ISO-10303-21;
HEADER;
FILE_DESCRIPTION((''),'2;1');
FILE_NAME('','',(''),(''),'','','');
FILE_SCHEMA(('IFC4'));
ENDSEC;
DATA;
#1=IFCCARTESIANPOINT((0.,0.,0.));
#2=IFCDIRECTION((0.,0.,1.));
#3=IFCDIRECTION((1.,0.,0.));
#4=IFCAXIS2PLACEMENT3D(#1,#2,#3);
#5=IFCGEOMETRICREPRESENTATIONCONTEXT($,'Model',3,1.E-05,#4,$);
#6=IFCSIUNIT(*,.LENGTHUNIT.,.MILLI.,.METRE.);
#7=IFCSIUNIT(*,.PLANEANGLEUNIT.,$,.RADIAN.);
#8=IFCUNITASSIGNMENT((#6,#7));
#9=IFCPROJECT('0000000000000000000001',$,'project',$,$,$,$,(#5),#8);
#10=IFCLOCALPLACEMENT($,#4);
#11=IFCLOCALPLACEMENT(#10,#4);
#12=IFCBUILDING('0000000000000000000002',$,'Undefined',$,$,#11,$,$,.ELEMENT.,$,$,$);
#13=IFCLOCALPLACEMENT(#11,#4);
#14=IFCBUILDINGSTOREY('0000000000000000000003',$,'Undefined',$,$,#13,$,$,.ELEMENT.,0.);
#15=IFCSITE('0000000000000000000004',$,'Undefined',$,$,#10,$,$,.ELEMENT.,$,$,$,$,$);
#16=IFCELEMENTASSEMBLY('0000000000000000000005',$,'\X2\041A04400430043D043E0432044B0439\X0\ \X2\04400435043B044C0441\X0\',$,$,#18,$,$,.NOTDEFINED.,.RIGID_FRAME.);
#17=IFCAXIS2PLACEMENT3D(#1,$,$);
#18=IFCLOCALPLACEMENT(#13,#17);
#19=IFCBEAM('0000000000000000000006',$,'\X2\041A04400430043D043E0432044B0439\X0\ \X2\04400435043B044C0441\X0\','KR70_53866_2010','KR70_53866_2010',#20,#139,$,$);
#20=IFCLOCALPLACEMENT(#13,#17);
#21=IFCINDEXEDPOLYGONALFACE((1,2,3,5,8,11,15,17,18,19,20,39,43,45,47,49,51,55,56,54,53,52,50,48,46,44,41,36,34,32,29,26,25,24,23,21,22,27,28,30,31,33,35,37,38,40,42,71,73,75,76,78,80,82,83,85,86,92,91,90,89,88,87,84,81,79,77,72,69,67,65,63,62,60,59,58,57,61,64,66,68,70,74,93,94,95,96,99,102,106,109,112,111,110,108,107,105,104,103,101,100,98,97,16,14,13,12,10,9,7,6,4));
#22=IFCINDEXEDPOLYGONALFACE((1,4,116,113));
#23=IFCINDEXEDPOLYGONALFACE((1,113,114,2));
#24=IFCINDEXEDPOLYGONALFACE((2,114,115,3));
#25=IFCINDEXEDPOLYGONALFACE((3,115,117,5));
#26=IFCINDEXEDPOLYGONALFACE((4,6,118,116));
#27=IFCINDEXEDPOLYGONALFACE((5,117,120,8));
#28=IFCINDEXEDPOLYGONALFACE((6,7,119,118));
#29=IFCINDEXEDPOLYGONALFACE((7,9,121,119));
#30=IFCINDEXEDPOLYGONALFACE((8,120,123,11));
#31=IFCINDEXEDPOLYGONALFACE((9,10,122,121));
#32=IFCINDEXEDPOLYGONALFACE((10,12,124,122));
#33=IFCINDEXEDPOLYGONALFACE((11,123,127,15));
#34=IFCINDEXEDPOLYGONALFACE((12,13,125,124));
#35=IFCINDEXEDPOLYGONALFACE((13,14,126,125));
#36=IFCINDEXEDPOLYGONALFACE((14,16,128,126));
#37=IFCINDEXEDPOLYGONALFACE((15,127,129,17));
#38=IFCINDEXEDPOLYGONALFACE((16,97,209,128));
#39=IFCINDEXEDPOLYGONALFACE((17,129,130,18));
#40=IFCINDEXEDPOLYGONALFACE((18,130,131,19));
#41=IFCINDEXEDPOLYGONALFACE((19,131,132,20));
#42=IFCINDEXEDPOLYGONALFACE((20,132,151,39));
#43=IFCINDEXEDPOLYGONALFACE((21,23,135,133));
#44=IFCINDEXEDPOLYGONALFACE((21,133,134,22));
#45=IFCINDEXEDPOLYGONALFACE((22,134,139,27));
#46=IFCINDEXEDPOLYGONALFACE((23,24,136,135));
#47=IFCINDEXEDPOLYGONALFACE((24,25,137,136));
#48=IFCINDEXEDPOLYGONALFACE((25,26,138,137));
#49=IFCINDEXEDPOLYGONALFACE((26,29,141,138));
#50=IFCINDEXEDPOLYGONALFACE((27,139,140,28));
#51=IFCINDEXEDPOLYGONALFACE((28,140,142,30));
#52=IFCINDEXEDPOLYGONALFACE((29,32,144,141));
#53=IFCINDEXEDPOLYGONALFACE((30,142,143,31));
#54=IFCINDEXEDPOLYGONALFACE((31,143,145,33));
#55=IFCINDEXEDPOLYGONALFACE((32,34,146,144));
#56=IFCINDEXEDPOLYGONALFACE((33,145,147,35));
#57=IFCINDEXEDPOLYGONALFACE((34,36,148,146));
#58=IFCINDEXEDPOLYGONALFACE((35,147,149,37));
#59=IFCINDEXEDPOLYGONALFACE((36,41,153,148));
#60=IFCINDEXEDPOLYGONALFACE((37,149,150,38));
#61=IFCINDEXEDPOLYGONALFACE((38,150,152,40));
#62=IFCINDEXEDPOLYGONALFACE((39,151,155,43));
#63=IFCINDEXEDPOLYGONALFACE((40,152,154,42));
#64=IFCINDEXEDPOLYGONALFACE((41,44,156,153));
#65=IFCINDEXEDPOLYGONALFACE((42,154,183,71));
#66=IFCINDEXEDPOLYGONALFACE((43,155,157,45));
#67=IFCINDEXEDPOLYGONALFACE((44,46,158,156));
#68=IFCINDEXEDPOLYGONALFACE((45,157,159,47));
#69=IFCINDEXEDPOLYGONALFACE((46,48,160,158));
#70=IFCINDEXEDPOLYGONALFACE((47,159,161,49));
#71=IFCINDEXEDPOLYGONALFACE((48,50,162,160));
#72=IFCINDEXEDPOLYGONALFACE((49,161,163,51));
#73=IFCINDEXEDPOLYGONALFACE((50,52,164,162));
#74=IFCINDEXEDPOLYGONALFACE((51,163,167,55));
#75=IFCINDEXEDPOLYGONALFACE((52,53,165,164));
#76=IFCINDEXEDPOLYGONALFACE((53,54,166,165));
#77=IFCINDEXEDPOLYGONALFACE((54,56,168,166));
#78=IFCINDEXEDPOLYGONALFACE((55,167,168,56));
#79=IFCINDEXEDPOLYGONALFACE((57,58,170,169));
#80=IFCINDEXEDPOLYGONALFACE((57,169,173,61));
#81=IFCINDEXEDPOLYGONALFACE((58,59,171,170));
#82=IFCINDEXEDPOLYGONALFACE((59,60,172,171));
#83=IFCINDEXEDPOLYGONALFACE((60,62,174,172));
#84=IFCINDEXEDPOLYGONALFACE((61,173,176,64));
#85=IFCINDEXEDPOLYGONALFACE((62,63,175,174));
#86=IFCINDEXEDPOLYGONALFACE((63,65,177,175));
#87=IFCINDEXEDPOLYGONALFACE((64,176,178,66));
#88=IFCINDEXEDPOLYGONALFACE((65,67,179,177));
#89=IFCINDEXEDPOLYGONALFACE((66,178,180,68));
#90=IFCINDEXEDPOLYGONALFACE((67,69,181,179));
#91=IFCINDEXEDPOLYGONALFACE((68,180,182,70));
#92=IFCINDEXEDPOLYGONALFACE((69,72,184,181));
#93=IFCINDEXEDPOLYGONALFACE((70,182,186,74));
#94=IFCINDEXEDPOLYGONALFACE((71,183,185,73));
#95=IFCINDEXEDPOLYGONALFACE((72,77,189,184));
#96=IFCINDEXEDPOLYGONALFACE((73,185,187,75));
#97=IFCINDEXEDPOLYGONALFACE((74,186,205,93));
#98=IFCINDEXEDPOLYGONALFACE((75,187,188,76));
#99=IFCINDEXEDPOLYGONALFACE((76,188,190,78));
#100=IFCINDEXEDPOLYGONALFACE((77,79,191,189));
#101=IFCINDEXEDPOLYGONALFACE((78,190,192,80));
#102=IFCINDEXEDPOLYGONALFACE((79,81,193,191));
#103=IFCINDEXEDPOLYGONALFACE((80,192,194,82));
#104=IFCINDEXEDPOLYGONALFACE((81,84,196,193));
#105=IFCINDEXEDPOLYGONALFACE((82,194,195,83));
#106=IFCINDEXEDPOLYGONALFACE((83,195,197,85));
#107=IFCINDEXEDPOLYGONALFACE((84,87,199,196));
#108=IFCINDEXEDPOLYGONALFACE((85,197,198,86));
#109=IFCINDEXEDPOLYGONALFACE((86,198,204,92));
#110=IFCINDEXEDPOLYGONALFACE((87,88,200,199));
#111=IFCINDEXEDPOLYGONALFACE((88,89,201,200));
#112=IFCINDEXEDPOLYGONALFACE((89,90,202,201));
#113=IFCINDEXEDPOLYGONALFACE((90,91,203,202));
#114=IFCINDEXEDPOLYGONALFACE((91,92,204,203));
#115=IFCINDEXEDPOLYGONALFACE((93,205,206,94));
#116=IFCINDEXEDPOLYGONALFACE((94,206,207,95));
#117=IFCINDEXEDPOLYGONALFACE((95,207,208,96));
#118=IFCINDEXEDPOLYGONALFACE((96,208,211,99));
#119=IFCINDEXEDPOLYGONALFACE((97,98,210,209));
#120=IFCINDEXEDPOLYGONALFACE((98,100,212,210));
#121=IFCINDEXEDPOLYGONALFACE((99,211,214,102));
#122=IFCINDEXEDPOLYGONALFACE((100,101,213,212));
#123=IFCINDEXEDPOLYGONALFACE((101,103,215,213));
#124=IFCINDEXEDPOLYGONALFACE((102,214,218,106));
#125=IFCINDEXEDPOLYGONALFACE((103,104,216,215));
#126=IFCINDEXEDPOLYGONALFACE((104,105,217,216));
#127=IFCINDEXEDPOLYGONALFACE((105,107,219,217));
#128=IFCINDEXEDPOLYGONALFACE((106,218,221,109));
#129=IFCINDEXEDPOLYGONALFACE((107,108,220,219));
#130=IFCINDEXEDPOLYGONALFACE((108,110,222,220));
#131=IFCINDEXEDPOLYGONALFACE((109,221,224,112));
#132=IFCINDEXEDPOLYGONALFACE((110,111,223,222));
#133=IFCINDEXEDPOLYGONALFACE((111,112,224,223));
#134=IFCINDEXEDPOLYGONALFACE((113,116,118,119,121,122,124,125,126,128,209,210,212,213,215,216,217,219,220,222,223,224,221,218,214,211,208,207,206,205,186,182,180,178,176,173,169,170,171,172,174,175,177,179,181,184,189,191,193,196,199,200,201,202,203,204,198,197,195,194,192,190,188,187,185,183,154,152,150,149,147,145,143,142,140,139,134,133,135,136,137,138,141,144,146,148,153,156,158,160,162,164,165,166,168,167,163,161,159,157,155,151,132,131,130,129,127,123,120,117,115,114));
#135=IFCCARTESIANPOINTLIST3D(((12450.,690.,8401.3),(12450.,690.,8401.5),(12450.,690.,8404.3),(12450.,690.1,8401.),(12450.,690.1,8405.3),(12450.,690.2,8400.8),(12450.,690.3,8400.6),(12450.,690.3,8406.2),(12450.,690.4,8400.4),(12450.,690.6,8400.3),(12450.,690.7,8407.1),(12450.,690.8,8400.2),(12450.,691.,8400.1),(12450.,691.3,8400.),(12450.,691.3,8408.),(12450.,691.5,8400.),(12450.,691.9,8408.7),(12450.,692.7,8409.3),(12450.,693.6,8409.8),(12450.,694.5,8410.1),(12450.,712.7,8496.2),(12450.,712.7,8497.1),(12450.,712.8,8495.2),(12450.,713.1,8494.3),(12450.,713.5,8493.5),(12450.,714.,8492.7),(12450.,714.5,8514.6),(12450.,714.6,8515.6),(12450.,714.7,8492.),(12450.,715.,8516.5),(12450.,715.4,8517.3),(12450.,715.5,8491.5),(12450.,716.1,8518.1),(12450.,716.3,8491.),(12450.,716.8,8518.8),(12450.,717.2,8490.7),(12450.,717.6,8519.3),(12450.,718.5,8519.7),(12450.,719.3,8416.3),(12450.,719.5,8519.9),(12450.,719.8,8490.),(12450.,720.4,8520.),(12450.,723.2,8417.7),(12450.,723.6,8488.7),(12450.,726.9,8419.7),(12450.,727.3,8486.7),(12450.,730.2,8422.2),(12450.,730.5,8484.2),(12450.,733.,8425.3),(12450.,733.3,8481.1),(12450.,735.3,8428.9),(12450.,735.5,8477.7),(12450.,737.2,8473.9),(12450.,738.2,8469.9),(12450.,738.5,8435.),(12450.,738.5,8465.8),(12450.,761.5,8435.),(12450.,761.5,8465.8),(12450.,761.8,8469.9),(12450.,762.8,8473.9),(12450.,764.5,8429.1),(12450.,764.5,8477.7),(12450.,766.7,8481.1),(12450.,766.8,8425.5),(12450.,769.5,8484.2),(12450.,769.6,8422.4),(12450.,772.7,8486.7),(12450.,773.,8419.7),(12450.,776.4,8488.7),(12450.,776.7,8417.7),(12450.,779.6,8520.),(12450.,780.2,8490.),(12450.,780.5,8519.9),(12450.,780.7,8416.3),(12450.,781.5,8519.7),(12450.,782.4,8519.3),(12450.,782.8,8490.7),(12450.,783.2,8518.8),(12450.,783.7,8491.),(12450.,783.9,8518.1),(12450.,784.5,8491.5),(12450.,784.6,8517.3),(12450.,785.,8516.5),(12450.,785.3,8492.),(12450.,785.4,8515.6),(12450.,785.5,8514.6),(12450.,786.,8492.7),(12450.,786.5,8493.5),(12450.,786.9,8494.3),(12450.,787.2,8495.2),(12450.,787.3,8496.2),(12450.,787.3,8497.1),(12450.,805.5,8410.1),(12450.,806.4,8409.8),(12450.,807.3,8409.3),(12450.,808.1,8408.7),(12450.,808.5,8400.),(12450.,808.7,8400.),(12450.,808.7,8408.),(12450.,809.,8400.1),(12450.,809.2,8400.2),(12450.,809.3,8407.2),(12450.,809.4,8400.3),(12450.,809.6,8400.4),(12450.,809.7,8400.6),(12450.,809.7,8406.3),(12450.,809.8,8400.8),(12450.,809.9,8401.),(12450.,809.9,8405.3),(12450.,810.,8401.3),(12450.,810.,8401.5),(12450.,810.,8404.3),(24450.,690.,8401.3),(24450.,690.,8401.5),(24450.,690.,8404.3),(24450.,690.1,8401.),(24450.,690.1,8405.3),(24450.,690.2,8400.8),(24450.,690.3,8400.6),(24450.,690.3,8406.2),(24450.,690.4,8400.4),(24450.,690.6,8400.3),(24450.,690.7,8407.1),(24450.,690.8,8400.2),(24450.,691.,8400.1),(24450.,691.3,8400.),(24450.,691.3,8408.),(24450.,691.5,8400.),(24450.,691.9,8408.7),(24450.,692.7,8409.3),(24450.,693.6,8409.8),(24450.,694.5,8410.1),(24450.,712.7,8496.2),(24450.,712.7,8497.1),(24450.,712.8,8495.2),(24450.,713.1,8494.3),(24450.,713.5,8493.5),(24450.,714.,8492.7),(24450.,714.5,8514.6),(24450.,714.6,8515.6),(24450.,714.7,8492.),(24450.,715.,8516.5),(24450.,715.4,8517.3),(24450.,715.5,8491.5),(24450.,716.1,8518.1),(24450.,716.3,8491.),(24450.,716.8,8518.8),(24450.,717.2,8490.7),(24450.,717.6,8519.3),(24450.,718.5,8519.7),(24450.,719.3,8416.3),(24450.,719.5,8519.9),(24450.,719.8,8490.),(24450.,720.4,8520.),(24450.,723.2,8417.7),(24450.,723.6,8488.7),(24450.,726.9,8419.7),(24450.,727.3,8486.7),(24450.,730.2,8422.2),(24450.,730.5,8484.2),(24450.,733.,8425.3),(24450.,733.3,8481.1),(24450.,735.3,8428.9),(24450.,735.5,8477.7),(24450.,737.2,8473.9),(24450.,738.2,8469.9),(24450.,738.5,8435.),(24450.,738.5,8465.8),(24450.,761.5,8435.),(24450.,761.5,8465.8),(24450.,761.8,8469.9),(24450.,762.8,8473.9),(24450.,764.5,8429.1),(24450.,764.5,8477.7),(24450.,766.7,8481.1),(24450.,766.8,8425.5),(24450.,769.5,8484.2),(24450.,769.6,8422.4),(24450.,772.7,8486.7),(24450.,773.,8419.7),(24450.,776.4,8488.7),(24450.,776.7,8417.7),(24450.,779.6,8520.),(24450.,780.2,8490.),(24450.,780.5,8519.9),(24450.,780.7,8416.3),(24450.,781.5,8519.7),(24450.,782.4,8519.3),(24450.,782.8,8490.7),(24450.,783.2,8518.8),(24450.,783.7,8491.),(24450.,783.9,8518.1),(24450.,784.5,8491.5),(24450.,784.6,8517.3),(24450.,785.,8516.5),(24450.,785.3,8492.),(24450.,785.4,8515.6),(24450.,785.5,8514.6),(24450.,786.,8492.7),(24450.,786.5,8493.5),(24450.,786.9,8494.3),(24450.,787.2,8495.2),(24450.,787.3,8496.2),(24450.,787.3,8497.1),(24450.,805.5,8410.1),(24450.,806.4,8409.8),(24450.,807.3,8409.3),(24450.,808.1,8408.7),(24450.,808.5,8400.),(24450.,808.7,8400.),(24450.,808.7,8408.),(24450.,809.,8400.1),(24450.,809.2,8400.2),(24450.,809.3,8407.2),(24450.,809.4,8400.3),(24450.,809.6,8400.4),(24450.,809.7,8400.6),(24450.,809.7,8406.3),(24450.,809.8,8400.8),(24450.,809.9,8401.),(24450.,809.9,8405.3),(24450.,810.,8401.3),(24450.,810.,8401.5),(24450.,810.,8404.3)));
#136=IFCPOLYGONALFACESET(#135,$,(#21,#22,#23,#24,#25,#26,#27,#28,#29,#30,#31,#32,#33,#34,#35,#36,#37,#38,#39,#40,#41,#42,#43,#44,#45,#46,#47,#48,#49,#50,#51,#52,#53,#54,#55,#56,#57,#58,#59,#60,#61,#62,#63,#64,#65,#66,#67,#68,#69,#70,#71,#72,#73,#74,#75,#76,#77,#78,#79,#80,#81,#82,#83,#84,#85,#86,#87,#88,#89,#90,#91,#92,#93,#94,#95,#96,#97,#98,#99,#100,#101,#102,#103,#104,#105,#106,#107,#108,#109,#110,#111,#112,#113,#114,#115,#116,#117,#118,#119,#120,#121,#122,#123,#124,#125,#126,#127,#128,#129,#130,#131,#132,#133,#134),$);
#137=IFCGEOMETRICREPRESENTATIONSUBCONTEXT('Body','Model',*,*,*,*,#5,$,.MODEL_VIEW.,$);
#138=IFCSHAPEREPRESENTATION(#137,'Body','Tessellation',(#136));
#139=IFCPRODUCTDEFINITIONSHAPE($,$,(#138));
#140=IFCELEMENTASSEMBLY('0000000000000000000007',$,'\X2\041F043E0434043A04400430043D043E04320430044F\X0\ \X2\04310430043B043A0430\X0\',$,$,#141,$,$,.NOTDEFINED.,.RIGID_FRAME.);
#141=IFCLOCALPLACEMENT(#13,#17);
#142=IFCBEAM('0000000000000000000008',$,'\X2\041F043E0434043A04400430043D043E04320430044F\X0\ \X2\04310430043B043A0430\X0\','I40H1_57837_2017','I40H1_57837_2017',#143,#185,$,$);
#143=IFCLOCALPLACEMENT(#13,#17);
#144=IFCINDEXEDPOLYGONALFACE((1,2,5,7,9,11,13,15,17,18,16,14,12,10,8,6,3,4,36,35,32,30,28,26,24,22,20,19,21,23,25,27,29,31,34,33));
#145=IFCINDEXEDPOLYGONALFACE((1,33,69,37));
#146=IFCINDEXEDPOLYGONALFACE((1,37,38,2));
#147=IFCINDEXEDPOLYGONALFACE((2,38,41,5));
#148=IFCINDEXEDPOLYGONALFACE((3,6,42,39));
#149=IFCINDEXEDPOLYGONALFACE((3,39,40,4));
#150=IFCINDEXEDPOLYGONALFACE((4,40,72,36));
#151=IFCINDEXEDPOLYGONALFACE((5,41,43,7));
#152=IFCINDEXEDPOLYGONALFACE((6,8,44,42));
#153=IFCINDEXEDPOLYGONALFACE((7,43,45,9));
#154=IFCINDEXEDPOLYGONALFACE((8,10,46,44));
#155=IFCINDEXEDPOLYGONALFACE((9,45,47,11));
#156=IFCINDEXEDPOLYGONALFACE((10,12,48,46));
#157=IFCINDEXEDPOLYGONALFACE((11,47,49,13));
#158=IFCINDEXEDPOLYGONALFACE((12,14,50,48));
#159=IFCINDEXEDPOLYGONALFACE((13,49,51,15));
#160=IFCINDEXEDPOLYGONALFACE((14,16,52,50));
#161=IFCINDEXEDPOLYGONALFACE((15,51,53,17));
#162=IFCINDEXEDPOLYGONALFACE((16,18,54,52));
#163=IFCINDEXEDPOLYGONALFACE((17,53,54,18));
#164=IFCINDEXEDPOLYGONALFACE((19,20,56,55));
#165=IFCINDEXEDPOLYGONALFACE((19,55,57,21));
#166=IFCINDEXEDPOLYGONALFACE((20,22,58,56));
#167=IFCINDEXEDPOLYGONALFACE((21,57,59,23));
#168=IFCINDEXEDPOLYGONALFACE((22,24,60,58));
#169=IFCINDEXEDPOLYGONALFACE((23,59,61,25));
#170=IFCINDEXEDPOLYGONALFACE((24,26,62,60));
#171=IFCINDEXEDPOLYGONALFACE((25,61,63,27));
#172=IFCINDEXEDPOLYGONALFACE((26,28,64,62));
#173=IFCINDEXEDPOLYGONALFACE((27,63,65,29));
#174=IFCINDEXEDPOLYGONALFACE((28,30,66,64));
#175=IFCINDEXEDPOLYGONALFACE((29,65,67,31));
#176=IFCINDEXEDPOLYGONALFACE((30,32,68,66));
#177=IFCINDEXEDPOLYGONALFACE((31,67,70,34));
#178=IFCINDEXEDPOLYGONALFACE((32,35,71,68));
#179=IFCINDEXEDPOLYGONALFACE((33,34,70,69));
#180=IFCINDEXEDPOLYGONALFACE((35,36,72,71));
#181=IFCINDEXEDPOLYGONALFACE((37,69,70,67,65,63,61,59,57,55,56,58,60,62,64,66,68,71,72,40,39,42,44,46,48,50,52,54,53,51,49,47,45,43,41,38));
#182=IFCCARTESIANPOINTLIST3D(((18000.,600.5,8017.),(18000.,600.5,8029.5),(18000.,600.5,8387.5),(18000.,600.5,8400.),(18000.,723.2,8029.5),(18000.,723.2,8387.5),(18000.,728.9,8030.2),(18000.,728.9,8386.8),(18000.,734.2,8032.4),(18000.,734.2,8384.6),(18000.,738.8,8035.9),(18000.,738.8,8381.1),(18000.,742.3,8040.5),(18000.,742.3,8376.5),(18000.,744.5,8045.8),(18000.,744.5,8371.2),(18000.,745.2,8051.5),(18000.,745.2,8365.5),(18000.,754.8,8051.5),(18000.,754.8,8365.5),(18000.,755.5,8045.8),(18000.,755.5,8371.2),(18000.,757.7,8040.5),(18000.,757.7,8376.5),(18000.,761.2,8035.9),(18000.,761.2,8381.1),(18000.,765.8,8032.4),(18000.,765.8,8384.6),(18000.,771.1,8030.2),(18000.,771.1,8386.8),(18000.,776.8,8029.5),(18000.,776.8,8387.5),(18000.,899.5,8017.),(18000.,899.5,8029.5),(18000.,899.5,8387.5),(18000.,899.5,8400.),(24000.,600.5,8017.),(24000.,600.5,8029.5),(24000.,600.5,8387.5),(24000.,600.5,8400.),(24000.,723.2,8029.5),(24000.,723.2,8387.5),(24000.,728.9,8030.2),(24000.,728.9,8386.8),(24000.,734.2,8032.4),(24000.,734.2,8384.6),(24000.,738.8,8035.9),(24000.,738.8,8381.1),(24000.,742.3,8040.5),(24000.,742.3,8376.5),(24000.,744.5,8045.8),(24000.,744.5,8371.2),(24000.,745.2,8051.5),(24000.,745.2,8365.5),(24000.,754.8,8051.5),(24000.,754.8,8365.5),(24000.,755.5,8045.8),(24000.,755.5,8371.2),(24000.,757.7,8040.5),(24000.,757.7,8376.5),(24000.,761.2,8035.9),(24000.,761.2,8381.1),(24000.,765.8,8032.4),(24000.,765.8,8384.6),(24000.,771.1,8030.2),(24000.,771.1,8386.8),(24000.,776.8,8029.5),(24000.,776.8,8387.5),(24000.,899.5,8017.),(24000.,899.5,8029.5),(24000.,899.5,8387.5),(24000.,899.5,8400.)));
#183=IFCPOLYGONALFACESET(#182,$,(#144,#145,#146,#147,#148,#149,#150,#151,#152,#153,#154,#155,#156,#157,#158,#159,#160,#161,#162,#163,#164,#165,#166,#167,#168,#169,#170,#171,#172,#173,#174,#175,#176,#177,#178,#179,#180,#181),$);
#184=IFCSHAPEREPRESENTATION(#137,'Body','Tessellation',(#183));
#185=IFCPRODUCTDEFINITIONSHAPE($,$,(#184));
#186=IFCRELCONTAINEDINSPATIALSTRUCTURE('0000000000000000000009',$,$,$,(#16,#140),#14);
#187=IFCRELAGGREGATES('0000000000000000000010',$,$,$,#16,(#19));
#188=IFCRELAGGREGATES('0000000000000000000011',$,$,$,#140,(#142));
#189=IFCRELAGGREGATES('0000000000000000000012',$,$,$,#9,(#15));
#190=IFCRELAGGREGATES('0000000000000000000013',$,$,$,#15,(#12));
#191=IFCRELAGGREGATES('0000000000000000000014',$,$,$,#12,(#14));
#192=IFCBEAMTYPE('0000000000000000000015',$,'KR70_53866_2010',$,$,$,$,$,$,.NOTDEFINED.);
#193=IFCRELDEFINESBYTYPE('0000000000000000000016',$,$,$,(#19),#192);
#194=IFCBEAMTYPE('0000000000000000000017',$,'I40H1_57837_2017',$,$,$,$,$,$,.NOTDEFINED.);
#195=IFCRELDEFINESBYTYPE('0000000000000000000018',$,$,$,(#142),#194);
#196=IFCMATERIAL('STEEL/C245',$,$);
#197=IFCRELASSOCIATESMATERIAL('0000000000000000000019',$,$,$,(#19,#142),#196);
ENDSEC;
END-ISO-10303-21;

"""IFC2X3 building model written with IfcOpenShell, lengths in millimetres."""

from ifc_helpers import new_model, si_unit, frame, origin_with_axes, origin_2d_with_axis, place, context, subcontext, project, spatial, polyline, i_section, outline, extrude, material, type_object, element, aggregate, save


model = new_model("IFC2X3")

# Units and contexts
model_context = context("Model", 3, precision=1e-05, world=origin_with_axes())
body_context = subcontext(model_context, "Body", "Model", "MODEL_VIEW")
ifc_project = project(units=[si_unit("LENGTHUNIT", "METRE", prefix="MILLI"), si_unit("PLANEANGLEUNIT", "RADIAN")], contexts=[model_context])

# Site, building, storey
site_placement = place(None, origin_with_axes())
site = spatial("IfcSite", under=ifc_project, at=site_placement, Name="Undefined", CompositionType="ELEMENT")
building_placement = place(site_placement, origin_with_axes())
building = spatial("IfcBuilding", under=site, at=building_placement, Name="Undefined", CompositionType="ELEMENT")
storey_placement = place(building_placement, origin_with_axes())
storey = spatial("IfcBuildingStorey", under=building, at=storey_placement, Name="Undefined", CompositionType="ELEMENT", Elevation=0.0)

# Shared definitions
ifc_material_1 = material(Name="STEEL/C245")

# Element assemblies, beams
assembly_1_placement = place(storey_placement, origin_with_axes())
assembly_1 = element("IfcElementAssembly", 1, at=assembly_1_placement, inside=storey, Name="Крановый рельс", AssemblyPlace="NOTDEFINED", PredefinedType="RIGID_FRAME")
beam_type_1 = type_object("IfcBeamType", Name="KR70_53866_2010", PredefinedType="NOTDEFINED")
beam_1_placement = place(assembly_1_placement, frame((12450.0, 750.0, 8460.0), z_axis=(0.0, 0.0, 1.0), x_axis=(1.0, 0.0, 0.0)))
beam_1 = element("IfcBeam", 2, at=beam_1_placement, type_object=beam_type_1, material=ifc_material_1, Name="Крановый рельс", Description="KR70_53866_2010", ObjectType="KR70_53866_2010", context=body_context, shape_type="SweptSolid", body=[
    extrude(outline(polyline([(58.7, -52.0), (59.3, -52.9), (59.7, -53.8), (59.9, -54.7), (60.0, -55.7), (60.0, -58.5), (60.0, -58.7), (59.9, -59.0), (59.8, -59.2), (59.7, -59.4), (59.6, -59.6), (59.4, -59.7), (59.2, -59.8), (59.0, -59.9), (58.7, -60.0), (58.5, -60.0), (-58.5, -60.0), (-58.7, -60.0), (-59.0, -59.9), (-59.2, -59.8), (-59.4, -59.7), (-59.6, -59.6), (-59.7, -59.4), (-59.8, -59.2), (-59.9, -59.0), (-60.0, -58.7), (-60.0, -58.5), (-60.0, -55.7), (-59.9, -54.7), (-59.7, -53.7), (-59.3, -52.8), (-58.7, -52.0), (-58.1, -51.3), (-57.3, -50.7), (-56.4, -50.2), (-55.5, -49.9), (-30.7, -43.7), (-26.7, -42.3), (-23.0, -40.3), (-19.6, -37.6), (-16.8, -34.5), (-14.5, -30.9), (-11.5, -25.0), (-11.5, 5.8), (-11.8, 9.9), (-12.8, 13.9), (-14.5, 17.7), (-16.7, 21.1), (-19.5, 24.2), (-22.7, 26.7), (-26.4, 28.7), (-30.2, 30.0), (-32.8, 30.7), (-33.7, 31.0), (-34.5, 31.5), (-35.3, 32.0), (-36.0, 32.7), (-36.5, 33.5), (-36.9, 34.3), (-37.2, 35.2), (-37.3, 36.2), (-37.3, 37.1), (-35.5, 54.6), (-35.4, 55.6), (-35.0, 56.5), (-34.6, 57.3), (-33.9, 58.1), (-33.2, 58.8), (-32.4, 59.3), (-31.5, 59.7), (-30.5, 59.9), (-29.6, 60.0), (29.6, 60.0), (30.5, 59.9), (31.5, 59.7), (32.4, 59.3), (33.2, 58.8), (33.9, 58.1), (34.6, 57.3), (35.0, 56.5), (35.4, 55.6), (35.5, 54.6), (37.3, 37.1), (37.3, 36.2), (37.2, 35.2), (36.9, 34.3), (36.5, 33.5), (36.0, 32.7), (35.3, 32.0), (34.5, 31.5), (33.7, 31.0), (32.8, 30.7), (30.2, 30.0), (26.4, 28.7), (22.7, 26.7), (19.5, 24.2), (16.7, 21.1), (14.5, 17.7), (12.8, 13.9), (11.8, 9.9), (11.5, 5.8), (11.5, -25.0), (14.7, -31.1), (17.0, -34.7), (19.8, -37.8), (23.1, -40.3), (26.8, -42.3), (30.7, -43.7), (55.5, -49.9), (56.4, -50.2), (57.3, -50.7), (58.1, -51.3), (58.7, -52.0)])), frame((12000.0, 0.0, 0.0), z_axis=(-1.0, 0.0, 0.0), x_axis=(0.0, -1.0, 0.0)), (0.0, 0.0, 1.0), 12000.0),
])
aggregate(assembly_1, [beam_1])
assembly_2_placement = place(storey_placement, origin_with_axes())
assembly_2 = element("IfcElementAssembly", 3, at=assembly_2_placement, inside=storey, Name="Подкрановая балка", AssemblyPlace="NOTDEFINED", PredefinedType="RIGID_FRAME")
beam_type_2 = type_object("IfcBeamType", Name="I40H1_57837_2017", PredefinedType="NOTDEFINED")
beam_2_placement = place(assembly_2_placement, frame((24000.0, 750.0, 8208.5), z_axis=(0.0, 0.0, 1.0), x_axis=(-1.0, 0.0, 0.0)))
beam_2 = element("IfcBeam", 4, at=beam_2_placement, type_object=beam_type_2, material=ifc_material_1, Name="Подкрановая балка", Description="I40H1_57837_2017", ObjectType="I40H1_57837_2017", context=body_context, shape_type="SweptSolid", body=[
    extrude(i_section(OverallWidth=299.0, OverallDepth=383.0, WebThickness=9.5, FlangeThickness=12.5, FilletRadius=22.0, at=origin_2d_with_axis()), frame((6000.0, 0.0, 0.0), z_axis=(-1.0, 0.0, 0.0), x_axis=(0.0, -1.0, 0.0)), (0.0, 0.0, 1.0), 6000.0),
])
aggregate(assembly_2, [beam_2])

save(model, "model.ifc")
